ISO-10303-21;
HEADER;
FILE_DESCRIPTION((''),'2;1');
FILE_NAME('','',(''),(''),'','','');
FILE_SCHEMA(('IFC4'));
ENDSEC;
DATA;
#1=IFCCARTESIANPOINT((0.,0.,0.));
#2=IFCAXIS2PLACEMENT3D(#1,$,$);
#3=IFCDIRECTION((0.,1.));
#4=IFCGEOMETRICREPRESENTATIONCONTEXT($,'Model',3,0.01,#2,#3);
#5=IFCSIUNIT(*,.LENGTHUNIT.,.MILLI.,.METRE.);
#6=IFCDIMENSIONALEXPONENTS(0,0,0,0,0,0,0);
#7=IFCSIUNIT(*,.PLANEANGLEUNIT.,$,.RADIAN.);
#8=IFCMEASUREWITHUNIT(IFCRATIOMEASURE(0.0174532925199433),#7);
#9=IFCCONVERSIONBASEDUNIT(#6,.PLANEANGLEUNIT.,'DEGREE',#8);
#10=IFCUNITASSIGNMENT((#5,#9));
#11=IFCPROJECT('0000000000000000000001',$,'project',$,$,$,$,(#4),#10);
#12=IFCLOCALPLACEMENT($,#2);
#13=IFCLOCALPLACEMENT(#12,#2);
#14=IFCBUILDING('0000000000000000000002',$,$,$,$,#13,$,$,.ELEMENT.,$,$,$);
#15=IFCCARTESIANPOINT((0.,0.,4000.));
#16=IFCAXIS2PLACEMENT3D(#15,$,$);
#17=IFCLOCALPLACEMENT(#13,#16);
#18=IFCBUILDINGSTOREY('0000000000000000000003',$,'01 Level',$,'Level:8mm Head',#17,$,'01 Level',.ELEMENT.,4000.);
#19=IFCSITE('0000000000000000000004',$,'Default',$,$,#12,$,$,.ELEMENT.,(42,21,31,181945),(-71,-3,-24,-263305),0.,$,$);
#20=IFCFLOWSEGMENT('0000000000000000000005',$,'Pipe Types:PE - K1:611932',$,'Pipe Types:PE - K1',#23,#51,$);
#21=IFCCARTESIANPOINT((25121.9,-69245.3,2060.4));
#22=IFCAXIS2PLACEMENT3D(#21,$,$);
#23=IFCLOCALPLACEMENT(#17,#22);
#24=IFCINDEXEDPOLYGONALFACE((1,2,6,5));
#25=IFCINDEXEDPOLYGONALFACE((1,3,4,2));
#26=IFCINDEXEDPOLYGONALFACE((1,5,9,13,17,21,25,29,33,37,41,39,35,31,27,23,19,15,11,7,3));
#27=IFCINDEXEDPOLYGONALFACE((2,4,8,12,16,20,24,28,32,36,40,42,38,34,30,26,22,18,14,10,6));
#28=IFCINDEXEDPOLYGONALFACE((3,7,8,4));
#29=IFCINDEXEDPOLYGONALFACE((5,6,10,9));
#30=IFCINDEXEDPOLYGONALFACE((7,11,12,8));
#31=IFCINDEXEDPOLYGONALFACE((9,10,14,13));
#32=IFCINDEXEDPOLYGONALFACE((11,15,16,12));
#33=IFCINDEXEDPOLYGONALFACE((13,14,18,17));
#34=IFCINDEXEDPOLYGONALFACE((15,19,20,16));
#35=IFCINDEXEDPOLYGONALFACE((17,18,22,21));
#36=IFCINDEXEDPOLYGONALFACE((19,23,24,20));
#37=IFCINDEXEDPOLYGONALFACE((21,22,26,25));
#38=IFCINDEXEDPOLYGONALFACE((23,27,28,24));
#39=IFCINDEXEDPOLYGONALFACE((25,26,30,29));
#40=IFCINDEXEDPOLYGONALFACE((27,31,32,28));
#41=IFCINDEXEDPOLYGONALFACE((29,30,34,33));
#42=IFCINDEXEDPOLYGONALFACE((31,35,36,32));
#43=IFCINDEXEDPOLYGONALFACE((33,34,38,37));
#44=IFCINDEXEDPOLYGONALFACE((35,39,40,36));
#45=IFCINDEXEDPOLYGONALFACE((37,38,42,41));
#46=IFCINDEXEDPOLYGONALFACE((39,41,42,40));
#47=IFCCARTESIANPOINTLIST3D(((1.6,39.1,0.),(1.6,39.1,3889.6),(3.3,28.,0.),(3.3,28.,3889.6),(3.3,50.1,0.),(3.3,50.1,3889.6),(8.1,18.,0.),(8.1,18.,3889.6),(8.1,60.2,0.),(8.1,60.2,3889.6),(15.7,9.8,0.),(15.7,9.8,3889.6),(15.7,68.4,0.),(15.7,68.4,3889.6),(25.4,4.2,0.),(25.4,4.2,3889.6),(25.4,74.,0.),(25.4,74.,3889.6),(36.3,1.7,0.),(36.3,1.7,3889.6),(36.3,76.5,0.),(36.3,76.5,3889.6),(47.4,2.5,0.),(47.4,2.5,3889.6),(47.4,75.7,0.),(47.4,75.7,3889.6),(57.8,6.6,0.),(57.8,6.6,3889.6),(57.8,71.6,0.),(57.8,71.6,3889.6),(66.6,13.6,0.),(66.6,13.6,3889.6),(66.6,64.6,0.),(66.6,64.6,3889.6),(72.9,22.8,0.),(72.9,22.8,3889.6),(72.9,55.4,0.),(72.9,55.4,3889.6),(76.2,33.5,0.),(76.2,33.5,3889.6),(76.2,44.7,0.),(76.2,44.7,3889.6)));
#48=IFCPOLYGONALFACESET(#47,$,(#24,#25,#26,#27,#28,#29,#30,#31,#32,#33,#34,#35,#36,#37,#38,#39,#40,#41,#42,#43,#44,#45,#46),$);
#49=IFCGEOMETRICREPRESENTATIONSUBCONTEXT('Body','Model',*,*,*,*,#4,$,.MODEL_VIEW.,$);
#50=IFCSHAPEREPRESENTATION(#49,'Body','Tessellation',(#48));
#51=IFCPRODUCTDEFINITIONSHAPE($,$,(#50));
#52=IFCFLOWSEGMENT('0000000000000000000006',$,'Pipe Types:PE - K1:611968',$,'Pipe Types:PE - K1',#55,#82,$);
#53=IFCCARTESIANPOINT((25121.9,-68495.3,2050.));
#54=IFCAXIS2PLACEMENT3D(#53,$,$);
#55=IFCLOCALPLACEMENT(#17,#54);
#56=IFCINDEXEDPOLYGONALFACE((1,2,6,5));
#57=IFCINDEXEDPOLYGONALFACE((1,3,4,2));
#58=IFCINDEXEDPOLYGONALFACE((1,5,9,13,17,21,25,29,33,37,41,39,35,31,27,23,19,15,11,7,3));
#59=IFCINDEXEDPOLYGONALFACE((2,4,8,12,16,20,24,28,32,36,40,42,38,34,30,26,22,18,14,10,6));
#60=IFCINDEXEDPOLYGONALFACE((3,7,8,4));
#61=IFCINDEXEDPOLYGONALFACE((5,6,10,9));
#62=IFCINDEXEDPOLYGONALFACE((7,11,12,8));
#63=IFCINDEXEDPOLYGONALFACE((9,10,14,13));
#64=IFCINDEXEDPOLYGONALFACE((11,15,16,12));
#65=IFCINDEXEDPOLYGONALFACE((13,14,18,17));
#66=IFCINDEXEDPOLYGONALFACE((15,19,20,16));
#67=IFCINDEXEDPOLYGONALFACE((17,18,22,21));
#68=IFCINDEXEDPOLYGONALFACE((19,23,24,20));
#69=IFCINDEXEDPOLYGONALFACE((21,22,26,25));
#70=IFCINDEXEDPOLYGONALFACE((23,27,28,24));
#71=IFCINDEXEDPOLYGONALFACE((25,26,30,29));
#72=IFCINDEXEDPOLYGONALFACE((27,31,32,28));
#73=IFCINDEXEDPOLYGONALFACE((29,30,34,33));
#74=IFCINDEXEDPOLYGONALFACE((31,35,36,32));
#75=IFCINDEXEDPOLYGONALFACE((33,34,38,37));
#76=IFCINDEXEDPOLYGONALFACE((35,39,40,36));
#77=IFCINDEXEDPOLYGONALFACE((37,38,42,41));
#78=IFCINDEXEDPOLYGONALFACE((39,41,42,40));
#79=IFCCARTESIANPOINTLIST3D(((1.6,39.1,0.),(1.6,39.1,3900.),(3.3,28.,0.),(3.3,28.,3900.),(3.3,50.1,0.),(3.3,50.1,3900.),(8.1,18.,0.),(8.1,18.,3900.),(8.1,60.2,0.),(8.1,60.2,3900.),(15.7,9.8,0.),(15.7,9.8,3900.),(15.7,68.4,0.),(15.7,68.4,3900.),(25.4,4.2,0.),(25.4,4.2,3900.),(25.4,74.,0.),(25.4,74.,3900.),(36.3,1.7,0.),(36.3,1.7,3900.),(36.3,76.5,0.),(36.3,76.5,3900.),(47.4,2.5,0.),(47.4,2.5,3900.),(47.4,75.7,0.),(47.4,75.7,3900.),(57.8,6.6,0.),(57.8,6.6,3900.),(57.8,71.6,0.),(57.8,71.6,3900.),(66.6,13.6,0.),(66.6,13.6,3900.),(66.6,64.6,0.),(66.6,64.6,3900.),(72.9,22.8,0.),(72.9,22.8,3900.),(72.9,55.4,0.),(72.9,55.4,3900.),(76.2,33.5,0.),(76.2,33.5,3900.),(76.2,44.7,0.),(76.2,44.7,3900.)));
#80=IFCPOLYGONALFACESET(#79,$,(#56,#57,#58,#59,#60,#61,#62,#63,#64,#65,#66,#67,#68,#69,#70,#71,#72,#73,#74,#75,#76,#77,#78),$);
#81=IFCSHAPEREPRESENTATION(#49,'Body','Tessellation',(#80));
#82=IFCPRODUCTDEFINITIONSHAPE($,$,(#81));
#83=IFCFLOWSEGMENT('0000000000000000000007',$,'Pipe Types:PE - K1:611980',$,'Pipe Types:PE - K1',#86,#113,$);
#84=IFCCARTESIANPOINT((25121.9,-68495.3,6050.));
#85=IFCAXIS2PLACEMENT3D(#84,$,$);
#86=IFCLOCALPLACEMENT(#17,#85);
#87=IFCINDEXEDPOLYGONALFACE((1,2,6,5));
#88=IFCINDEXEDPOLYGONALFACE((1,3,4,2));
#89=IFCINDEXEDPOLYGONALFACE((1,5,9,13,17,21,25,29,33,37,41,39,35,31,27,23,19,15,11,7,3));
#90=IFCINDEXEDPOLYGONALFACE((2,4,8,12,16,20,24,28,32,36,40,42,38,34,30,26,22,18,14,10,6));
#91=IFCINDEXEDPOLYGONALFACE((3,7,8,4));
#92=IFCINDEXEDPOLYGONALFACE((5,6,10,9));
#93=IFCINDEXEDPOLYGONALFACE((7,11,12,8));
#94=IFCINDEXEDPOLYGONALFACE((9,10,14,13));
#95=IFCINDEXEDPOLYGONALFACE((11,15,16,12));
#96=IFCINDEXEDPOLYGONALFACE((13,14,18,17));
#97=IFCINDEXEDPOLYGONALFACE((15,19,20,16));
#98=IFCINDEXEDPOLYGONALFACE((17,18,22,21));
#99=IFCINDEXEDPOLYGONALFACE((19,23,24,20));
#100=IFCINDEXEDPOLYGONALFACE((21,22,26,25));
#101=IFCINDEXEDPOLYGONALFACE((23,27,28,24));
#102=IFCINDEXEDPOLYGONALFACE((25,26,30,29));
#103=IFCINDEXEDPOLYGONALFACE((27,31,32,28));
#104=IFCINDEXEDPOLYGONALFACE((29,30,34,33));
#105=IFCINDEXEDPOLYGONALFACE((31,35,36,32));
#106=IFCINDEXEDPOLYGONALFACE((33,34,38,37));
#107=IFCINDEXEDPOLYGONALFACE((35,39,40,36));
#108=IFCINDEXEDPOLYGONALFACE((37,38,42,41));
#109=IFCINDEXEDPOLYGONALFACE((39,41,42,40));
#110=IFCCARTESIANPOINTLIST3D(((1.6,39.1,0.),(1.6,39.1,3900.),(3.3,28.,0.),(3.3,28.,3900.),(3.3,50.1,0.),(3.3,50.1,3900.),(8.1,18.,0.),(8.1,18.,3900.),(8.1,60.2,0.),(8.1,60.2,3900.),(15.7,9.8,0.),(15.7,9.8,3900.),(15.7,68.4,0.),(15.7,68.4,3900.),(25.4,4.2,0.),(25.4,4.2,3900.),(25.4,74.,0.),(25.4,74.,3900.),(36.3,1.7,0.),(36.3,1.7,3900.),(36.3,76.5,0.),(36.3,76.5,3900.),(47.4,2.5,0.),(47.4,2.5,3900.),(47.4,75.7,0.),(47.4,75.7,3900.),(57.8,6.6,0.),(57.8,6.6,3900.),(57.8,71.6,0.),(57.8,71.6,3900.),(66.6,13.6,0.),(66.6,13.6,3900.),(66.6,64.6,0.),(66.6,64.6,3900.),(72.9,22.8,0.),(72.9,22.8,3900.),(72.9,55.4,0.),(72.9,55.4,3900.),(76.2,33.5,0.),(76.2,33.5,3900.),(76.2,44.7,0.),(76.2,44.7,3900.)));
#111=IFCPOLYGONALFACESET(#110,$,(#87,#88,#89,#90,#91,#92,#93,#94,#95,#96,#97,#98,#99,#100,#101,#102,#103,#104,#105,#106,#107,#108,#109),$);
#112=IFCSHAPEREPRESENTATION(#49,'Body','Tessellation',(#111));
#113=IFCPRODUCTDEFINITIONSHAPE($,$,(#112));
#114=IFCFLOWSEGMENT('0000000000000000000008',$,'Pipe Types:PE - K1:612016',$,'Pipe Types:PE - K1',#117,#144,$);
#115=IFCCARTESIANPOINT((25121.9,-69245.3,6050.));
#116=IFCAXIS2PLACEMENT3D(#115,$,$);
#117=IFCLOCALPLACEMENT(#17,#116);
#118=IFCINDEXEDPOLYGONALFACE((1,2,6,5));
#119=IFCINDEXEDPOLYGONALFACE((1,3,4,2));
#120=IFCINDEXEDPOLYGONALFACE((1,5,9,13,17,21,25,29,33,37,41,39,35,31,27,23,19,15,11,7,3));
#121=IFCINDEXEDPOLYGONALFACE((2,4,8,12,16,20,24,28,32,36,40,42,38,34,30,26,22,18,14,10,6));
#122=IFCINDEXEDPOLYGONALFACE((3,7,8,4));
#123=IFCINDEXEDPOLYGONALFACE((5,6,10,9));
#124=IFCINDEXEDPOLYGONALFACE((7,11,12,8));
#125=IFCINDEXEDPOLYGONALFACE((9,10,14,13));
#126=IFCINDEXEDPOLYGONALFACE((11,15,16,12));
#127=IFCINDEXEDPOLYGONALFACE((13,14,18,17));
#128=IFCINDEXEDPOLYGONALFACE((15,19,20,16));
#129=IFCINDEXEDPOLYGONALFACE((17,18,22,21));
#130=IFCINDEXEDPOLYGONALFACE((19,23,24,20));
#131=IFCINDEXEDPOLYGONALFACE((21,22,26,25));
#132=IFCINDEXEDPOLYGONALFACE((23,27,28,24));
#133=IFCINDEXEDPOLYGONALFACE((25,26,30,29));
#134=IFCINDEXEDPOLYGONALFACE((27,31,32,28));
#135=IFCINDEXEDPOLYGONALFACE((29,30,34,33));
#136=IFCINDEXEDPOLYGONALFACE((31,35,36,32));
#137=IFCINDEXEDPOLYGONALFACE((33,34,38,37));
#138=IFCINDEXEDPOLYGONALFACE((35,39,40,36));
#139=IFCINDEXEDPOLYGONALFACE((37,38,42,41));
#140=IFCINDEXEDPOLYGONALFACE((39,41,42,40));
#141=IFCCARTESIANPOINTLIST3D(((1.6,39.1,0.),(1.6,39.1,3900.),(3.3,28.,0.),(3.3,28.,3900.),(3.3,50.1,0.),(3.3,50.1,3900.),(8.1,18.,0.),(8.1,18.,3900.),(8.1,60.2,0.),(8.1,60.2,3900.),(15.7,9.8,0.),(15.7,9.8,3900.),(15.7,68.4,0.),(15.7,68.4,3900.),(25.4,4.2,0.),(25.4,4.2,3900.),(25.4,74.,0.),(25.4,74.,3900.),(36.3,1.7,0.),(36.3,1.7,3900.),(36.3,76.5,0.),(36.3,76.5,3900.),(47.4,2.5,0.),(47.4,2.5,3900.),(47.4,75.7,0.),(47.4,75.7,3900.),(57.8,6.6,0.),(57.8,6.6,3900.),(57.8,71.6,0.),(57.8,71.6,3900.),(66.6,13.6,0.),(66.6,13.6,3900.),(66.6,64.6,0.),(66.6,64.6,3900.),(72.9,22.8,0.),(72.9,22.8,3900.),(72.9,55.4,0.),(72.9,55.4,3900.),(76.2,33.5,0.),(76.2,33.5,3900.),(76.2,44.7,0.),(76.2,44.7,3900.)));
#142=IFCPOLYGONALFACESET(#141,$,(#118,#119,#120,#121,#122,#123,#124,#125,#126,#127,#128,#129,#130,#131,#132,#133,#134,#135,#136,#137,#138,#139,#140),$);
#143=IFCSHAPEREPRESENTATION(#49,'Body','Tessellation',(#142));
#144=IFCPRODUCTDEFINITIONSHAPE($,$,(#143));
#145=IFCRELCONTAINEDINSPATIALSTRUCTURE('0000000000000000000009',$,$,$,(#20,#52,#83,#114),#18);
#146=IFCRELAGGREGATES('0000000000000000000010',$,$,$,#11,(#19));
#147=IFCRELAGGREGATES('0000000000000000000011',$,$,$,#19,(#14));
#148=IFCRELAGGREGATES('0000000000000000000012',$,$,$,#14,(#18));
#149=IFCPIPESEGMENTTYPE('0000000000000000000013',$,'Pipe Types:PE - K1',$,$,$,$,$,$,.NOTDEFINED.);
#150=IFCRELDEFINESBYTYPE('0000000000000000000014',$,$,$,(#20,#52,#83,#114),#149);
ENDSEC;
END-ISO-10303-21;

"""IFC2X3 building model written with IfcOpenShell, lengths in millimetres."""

from ifc_helpers import new_model, entity, si_unit, converted_unit, direction, frame, origin, origin_2d_with_axis, place, context, subcontext, project, spatial, circle, extrude, type_object, element, save


model = new_model("IFC2X3")

# Units and contexts
model_context = context("Model", 3, precision=0.01, world=origin(), true_north=direction((0.0, 1.0)))
body_context = subcontext(model_context, "Body", "Model", "MODEL_VIEW")
ifc_project = project(units=[si_unit("LENGTHUNIT", "METRE", prefix="MILLI"), converted_unit("PLANEANGLEUNIT", "DEGREE", entity("IfcRatioMeasure", 0.0174532925199433), si_unit("PLANEANGLEUNIT", "RADIAN"), dimensions=[0, 0, 0, 0, 0, 0, 0])], contexts=[model_context])

# Site, building, storey
site_placement = place(None, origin())
site = spatial("IfcSite", under=ifc_project, at=site_placement, Name="Default", CompositionType="ELEMENT", RefLatitude=(42, 21, 31, 181945), RefLongitude=(-71, -3, -24, -263305), RefElevation=0.0)
building_placement = place(site_placement, origin())
building = spatial("IfcBuilding", under=site, at=building_placement, CompositionType="ELEMENT")
storey_placement = place(building_placement, frame((0.0, 0.0, 4000.0)))
storey = spatial("IfcBuildingStorey", under=building, at=storey_placement, Name="01 Level", ObjectType="Level:8mm Head", LongName="01 Level", CompositionType="ELEMENT", Elevation=4000.0)

# Flow segments
pipe_segment_type_1 = type_object("IfcPipeSegmentType", Name="Pipe Types:PE - K1", PredefinedType="NOTDEFINED")
flow_segment_1_placement = place(storey_placement, frame((25121.9, -69245.3, 2060.4)))
element("IfcFlowSegment", 1, at=flow_segment_1_placement, inside=storey, type_object=pipe_segment_type_1, Name="Pipe Types:PE - K1:611932", ObjectType="Pipe Types:PE - K1", context=body_context, shape_type="SweptSolid", body=[
    extrude(circle(Radius=37.5, at=origin_2d_with_axis()), frame((39.1, 39.1, 0.0), z_axis=(0.0, 0.0, 1.0), x_axis=(-1.0, 0.0, 0.0)), (0.0, 0.0, 1.0), 3889.6),
])
for number, where, name in (
    (2, (25121.9, -68495.3, 2050.0), "Pipe Types:PE - K1:611968"),
    (3, (25121.9, -68495.3, 6050.0), "Pipe Types:PE - K1:611980"),
    (4, (25121.9, -69245.3, 6050.0), "Pipe Types:PE - K1:612016"),
):
    element("IfcFlowSegment", number, at=place(storey_placement, frame(where)), inside=storey, type_object=pipe_segment_type_1, Name=name, ObjectType="Pipe Types:PE - K1", context=body_context, shape_type="SweptSolid", body=[
        extrude(circle(Radius=37.5, at=origin_2d_with_axis()), frame((39.1, 39.1, 0.0), z_axis=(0.0, 0.0, 1.0), x_axis=(-1.0, 0.0, 0.0)), (0.0, 0.0, 1.0), 3900.0),
    ])

save(model, "model.ifc")
